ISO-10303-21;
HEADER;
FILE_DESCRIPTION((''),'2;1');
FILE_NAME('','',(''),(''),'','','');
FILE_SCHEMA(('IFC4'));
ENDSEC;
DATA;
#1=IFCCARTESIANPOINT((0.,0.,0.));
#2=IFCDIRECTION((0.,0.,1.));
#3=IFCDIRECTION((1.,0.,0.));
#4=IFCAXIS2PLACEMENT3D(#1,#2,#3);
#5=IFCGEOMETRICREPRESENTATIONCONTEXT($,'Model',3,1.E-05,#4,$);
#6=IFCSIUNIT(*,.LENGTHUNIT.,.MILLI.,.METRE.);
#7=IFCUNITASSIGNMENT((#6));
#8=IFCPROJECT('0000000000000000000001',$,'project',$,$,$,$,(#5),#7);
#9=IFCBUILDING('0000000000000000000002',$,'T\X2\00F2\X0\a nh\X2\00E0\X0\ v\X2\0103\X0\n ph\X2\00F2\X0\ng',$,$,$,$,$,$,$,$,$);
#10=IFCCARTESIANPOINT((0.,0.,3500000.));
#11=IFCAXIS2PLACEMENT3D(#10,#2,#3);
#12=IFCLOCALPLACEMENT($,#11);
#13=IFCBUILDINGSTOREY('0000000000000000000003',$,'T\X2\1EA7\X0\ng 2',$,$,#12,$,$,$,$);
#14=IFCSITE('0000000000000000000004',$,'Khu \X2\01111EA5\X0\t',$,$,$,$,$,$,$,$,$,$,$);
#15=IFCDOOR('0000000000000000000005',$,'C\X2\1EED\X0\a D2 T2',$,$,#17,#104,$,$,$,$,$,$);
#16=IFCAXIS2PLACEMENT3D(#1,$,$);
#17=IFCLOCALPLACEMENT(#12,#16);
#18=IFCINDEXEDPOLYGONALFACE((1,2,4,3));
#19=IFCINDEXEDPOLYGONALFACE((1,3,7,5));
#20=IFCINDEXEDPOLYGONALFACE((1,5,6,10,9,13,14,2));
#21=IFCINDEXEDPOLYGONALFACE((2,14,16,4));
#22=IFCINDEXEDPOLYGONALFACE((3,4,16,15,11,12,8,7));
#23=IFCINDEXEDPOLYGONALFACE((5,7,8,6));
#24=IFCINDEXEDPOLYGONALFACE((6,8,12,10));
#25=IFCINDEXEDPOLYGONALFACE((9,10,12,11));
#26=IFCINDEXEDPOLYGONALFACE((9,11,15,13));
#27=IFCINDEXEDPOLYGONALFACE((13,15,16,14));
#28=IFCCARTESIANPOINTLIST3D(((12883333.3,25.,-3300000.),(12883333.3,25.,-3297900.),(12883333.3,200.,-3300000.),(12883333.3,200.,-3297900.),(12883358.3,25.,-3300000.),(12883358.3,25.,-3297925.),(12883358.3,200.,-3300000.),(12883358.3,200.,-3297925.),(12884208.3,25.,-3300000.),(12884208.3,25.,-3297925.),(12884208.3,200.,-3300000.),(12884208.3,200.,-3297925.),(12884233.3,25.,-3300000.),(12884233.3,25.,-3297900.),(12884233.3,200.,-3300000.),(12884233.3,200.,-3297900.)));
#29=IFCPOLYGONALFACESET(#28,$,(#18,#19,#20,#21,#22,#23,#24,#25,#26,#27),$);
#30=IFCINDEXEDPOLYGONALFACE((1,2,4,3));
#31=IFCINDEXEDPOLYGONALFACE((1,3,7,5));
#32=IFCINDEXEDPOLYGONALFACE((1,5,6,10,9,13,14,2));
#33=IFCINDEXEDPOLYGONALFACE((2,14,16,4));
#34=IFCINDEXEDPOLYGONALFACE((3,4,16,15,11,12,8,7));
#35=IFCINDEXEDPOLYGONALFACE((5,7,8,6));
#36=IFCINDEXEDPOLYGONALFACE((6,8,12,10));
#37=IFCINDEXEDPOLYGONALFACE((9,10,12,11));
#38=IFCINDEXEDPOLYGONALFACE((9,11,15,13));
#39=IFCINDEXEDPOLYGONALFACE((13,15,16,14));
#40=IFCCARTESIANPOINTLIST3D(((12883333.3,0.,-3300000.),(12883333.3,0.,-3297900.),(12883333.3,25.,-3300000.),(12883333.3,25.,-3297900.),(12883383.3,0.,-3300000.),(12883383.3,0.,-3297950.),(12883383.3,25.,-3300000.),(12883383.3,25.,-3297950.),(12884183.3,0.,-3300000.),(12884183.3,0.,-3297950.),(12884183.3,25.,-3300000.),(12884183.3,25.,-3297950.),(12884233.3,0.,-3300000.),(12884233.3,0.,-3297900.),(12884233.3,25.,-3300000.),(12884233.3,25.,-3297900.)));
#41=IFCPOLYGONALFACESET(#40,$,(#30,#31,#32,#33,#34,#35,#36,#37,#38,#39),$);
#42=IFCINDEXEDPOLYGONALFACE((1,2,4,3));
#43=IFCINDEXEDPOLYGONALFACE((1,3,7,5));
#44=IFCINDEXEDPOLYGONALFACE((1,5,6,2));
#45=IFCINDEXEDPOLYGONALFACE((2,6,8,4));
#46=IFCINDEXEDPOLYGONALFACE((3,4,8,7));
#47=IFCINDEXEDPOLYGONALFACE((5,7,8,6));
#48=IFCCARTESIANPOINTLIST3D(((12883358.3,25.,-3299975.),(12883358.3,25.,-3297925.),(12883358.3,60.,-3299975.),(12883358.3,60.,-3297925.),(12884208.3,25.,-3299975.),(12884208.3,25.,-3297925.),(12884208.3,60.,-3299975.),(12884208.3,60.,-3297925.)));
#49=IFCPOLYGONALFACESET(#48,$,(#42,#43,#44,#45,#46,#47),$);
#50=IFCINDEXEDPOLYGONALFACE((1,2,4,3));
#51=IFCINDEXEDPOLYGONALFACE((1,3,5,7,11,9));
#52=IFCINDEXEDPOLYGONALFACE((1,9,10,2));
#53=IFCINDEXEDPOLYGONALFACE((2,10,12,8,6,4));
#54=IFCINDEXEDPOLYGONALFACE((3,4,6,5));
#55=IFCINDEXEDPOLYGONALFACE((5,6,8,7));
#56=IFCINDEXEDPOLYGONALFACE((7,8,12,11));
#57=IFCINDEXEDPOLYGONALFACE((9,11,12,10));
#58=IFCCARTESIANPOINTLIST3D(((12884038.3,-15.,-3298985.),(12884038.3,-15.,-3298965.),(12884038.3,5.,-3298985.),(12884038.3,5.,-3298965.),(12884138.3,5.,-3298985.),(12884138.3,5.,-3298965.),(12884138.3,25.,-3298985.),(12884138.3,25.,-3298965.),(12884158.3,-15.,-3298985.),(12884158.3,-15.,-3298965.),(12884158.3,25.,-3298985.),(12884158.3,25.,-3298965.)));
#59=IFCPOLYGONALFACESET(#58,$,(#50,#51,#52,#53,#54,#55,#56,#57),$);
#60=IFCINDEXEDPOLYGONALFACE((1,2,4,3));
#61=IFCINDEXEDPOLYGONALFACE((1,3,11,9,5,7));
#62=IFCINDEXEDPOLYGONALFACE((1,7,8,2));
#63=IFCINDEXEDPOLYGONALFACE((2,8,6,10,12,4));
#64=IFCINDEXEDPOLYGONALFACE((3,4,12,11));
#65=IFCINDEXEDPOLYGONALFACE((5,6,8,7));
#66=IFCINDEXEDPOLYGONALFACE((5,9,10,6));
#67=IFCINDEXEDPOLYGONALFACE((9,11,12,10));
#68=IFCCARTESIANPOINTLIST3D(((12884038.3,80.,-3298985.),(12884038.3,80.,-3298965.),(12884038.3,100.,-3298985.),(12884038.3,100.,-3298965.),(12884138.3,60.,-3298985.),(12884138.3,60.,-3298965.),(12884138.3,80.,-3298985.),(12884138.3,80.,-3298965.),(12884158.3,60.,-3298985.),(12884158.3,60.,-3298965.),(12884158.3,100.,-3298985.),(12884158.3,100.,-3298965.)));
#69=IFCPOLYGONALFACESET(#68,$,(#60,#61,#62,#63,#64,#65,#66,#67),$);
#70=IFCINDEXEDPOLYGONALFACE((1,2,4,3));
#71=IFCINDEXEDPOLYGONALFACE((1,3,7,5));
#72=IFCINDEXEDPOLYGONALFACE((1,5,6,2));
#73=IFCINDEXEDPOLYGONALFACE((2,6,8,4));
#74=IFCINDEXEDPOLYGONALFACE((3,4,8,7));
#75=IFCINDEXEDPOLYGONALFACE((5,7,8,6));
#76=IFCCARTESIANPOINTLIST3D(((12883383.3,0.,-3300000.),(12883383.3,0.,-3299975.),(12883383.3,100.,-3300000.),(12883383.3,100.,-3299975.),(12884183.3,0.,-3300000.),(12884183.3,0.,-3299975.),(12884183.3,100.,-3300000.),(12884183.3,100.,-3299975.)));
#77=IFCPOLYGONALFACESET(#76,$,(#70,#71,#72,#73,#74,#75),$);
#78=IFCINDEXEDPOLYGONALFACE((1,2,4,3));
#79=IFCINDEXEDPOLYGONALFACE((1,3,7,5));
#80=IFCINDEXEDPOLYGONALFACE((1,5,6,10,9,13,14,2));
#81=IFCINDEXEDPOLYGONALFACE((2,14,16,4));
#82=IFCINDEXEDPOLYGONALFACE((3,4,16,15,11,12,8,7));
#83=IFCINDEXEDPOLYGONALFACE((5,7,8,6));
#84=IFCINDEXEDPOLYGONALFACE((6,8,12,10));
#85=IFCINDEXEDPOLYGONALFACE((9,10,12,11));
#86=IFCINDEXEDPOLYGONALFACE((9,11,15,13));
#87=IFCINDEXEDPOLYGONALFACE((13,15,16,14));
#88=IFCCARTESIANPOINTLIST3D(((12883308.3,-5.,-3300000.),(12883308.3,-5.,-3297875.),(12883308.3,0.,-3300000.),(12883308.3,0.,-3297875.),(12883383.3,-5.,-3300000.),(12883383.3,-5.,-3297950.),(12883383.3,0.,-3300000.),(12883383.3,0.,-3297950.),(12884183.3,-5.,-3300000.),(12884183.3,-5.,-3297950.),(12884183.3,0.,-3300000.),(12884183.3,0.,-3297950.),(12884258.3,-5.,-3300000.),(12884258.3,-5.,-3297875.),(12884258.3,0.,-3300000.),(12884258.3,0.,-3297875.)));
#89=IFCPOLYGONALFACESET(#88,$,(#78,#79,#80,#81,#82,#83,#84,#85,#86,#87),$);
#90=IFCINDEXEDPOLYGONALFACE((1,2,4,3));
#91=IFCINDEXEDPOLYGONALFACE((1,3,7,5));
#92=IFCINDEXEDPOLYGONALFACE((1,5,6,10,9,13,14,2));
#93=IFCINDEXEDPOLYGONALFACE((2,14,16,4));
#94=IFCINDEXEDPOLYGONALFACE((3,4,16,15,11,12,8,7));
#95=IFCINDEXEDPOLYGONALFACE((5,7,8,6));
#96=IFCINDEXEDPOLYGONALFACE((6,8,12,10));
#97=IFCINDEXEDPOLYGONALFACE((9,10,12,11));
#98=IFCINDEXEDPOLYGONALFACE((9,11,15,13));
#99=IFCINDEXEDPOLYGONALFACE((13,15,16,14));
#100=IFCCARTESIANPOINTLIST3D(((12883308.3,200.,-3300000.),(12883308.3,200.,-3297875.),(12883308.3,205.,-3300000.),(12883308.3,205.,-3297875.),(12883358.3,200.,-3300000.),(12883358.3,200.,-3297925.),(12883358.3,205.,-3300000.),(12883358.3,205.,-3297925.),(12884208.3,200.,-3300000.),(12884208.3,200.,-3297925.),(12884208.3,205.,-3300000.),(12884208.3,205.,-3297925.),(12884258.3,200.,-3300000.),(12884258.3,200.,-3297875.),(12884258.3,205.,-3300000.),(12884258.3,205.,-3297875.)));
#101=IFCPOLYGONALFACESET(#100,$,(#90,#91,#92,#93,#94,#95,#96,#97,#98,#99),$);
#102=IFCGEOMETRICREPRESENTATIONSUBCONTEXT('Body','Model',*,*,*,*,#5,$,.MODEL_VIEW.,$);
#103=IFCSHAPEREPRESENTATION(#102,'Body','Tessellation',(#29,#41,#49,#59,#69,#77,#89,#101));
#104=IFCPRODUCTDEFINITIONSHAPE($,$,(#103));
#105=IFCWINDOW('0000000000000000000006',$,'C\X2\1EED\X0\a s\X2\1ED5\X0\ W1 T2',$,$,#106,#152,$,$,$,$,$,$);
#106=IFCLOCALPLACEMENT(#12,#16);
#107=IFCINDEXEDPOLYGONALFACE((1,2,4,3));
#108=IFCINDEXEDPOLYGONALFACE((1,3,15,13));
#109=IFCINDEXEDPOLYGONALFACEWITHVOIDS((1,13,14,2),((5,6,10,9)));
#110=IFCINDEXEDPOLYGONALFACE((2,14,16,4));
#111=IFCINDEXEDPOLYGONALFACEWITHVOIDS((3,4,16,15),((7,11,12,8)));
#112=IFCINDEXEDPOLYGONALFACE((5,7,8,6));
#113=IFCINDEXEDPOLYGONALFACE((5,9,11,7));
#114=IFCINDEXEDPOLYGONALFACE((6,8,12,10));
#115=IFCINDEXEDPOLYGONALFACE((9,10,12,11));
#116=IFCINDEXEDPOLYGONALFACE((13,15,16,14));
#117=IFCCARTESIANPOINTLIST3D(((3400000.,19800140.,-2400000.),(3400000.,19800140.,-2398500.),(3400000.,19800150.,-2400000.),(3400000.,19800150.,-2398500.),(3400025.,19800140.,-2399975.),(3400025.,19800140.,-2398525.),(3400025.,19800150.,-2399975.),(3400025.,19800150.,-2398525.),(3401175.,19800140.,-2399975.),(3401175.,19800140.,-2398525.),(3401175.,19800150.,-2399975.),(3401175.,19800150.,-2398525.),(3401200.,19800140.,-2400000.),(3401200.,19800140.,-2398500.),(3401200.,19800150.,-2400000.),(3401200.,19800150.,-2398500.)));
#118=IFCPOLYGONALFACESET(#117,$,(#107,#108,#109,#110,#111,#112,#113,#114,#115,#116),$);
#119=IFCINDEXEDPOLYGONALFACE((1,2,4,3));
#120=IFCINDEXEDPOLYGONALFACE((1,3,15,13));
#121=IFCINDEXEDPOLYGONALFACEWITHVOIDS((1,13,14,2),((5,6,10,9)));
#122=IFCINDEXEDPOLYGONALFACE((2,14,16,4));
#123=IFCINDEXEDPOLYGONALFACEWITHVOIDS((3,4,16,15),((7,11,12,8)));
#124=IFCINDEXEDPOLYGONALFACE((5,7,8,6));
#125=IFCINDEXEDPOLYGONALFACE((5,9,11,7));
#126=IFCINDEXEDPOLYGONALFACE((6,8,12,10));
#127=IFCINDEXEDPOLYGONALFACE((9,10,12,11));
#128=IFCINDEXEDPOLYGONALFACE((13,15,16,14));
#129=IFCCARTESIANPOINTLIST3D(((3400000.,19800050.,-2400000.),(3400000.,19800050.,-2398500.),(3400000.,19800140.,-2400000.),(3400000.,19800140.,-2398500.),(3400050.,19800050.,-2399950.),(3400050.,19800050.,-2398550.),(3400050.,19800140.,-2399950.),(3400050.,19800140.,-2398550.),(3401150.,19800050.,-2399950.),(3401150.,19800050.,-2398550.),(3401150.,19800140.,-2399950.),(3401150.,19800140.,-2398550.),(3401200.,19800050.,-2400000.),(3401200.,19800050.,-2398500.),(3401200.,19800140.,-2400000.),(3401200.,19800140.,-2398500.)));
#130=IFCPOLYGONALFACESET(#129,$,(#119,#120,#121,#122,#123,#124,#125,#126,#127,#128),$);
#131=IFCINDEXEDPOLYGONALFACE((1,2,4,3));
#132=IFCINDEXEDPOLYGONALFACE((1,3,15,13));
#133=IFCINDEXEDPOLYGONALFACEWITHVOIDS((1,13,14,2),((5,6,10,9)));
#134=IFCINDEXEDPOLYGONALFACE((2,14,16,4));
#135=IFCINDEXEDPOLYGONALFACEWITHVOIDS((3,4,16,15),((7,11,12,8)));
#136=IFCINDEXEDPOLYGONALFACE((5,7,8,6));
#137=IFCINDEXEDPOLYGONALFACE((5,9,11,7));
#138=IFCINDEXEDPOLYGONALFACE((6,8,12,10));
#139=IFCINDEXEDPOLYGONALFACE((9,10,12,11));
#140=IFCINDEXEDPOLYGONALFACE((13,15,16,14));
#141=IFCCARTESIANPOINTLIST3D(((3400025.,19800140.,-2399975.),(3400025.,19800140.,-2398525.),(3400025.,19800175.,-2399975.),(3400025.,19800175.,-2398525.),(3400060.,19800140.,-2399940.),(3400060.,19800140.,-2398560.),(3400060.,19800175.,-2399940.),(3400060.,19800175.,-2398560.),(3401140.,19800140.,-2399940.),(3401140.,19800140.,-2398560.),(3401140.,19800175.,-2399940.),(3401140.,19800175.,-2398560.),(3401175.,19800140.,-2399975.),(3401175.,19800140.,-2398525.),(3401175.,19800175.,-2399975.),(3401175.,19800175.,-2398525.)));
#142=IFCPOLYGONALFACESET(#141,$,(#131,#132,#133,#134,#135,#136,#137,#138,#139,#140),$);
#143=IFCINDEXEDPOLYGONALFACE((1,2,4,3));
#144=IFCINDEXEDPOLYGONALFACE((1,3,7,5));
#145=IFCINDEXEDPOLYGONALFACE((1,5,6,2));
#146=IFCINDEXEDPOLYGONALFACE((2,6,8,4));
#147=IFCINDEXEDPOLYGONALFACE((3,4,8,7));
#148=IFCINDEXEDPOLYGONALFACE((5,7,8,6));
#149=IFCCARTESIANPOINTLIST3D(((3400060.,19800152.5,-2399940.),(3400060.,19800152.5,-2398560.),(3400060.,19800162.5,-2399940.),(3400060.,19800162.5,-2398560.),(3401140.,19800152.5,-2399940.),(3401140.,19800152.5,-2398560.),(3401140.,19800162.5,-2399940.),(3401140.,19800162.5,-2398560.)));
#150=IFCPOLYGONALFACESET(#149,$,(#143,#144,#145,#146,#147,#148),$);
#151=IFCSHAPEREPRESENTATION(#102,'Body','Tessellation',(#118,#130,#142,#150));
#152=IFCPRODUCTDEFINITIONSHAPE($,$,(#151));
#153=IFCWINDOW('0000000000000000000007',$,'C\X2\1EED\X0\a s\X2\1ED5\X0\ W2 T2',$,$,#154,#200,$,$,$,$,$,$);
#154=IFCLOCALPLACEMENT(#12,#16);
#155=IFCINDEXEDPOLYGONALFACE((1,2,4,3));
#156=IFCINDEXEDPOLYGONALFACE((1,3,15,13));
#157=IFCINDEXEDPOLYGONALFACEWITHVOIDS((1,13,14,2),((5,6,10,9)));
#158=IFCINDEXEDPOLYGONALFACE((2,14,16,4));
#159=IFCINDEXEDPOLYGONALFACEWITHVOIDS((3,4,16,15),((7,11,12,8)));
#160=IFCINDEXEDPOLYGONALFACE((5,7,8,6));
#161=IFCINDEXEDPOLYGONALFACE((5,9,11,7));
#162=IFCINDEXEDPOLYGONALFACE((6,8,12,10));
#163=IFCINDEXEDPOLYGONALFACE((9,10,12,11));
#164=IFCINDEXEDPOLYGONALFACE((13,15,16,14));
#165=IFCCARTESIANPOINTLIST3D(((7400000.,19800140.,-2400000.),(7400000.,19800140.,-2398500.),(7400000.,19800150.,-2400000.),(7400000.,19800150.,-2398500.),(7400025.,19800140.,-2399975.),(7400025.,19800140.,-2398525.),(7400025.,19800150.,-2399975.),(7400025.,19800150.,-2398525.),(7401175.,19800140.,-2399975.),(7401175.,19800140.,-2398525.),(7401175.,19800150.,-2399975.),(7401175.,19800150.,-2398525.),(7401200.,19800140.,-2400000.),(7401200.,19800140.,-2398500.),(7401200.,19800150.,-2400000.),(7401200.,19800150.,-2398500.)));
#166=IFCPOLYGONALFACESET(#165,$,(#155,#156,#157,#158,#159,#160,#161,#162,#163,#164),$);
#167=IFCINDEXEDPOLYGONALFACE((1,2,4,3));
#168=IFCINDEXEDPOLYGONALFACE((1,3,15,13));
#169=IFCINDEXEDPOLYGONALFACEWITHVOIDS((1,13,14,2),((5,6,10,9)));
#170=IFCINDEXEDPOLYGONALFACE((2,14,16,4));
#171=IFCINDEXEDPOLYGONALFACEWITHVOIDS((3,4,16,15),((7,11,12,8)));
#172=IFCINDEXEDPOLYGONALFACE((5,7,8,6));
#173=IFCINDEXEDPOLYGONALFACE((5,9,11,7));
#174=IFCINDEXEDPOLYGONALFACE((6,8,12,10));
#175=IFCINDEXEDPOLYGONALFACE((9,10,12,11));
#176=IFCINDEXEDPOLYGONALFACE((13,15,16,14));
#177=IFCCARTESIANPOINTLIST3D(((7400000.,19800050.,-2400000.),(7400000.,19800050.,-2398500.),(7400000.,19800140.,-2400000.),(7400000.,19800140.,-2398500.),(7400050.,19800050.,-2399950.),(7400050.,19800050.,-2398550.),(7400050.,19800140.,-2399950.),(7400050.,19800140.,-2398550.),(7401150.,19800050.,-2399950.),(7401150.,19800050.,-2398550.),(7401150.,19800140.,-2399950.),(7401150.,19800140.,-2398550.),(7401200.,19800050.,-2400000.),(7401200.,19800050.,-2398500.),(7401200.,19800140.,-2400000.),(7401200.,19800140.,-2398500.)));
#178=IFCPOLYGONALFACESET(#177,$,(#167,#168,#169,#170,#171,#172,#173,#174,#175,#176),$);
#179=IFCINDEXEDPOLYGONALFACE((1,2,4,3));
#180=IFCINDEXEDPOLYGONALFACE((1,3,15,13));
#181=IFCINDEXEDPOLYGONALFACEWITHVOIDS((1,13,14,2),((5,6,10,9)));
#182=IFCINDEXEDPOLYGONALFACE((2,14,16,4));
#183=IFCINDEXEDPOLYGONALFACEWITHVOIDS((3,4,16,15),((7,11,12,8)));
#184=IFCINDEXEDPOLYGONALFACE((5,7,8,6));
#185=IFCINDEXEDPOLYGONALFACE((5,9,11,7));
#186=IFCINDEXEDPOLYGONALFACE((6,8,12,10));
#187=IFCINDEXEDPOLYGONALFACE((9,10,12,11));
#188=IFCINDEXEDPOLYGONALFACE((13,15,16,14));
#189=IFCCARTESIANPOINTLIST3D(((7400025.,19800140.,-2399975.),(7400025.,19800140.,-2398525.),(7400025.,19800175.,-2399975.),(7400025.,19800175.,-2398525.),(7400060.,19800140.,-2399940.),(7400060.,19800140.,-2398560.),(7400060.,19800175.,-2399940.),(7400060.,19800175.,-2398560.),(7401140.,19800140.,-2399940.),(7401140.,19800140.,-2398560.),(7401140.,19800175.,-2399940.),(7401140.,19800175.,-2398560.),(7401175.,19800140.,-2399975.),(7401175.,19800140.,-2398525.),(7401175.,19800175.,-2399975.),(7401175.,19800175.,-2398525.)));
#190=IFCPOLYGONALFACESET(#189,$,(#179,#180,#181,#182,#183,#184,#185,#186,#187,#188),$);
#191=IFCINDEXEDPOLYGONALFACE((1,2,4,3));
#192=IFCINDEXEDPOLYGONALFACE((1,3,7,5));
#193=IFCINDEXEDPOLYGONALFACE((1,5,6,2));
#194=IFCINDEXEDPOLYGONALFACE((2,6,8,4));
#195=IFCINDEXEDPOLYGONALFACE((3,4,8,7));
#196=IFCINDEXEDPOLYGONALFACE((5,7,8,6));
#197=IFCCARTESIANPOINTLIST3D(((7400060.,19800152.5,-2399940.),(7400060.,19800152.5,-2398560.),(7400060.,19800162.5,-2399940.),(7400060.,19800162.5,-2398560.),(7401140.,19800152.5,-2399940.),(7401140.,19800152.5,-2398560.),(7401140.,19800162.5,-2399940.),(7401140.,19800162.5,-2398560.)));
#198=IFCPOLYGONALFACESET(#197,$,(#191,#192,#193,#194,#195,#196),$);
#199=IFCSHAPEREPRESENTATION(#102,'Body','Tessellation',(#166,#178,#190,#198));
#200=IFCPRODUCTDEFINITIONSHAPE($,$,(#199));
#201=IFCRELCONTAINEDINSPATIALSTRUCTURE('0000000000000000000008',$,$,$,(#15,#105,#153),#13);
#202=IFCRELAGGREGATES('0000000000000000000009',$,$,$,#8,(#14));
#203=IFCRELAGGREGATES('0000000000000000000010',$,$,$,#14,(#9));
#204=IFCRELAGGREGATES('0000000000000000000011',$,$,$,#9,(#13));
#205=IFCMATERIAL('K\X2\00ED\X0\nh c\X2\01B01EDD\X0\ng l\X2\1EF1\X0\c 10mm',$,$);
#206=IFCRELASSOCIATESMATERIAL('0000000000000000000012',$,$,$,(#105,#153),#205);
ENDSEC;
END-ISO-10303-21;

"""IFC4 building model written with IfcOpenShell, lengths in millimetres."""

from ifc_helpers import new_model, si_unit, frame, origin_with_axes, place, context, subcontext, project, spatial, line, indexed_curve, outline, extrude, material, element, save


model = new_model("IFC4")

# Units and contexts
model_context = context("Model", 3, precision=1e-05, world=origin_with_axes())
body_context = subcontext(model_context, "Body", "Model", "MODEL_VIEW")
ifc_project = project(units=[si_unit("LENGTHUNIT", "METRE", prefix="MILLI")], contexts=[model_context])

# Site, building, storey
site = spatial("IfcSite", under=ifc_project, Name="Khu đất")
building = spatial("IfcBuilding", under=site, Name="Tòa nhà văn phòng")
storey_placement = place(None, frame((0.0, 0.0, 3500000.0), z_axis=(0.0, 0.0, 1.0), x_axis=(1.0, 0.0, 0.0)))
storey = spatial("IfcBuildingStorey", under=building, at=storey_placement, Name="Tầng 2")

# Door
door_1_placement = place(storey_placement, frame((12883333.3, 0.0, -3300000.0), z_axis=(0.0, 0.0, 1.0), x_axis=(1.0, 0.0, 0.0)))
element("IfcDoor", 1, at=door_1_placement, inside=storey, Name="Cửa D2 T2", context=body_context, shape_type="SolidModel", body=[
    extrude(outline(indexed_curve([(0.0, 0.0), (0.0, 2100.0), (900.0, 2100.0), (900.0, 0.0), (875.0, 0.0), (875.0, 2075.0), (25.0, 2075.0), (25.0, 0.0)], segments=[line(1, 2, 3, 4, 5, 6, 7, 8, 1)])), frame((0.0, 25.0, 0.0), z_axis=(0.0, -1.0, 0.0), x_axis=(1.0, 0.0, 0.0)), (0.0, 0.0, -1.0), 175.0),
    extrude(outline(indexed_curve([(0.0, 0.0), (0.0, 2100.0), (900.0, 2100.0), (900.0, 0.0), (850.0, 0.0), (850.0, 2050.0), (50.0, 2050.0), (50.0, 0.0)], segments=[line(1, 2, 3, 4, 5, 6, 7, 8, 1)])), frame((0.0, 0.0, 0.0), z_axis=(0.0, -1.0, 0.0), x_axis=(1.0, 0.0, 0.0)), (0.0, 0.0, -1.0), 25.0),
    extrude(outline(indexed_curve([(0.0, 0.0), (850.0, 0.0), (850.0, 35.0), (0.0, 35.0)], segments=[line(1, 2, 3, 4, 1)])), frame((25.0, 25.0, 25.0), z_axis=(0.0, 0.0, 1.0), x_axis=(1.0, 0.0, 0.0)), (0.0, 0.0, 1.0), 2050.0),
    extrude(outline(indexed_curve([(0.0, 0.0), (0.0, -40.0), (-120.0, -40.0), (-120.0, -20.0), (-20.0, -20.0), (-20.0, 0.0)], segments=[line(1, 2, 3, 4, 5, 6, 1)])), frame((825.0, 25.0, 1015.0), z_axis=(0.0, 0.0, 1.0), x_axis=(1.0, 0.0, 0.0)), (0.0, 0.0, 1.0), 20.0),
    extrude(outline(indexed_curve([(0.0, 0.0), (0.0, 40.0), (-120.0, 40.0), (-120.0, 20.0), (-20.0, 20.0), (-20.0, 0.0)], segments=[line(1, 2, 3, 4, 5, 6, 1)])), frame((825.0, 60.0, 1015.0), z_axis=(0.0, 0.0, 1.0), x_axis=(1.0, 0.0, 0.0)), (0.0, 0.0, 1.0), 20.0),
    extrude(outline(indexed_curve([(0.0, 0.0), (800.0, 0.0), (800.0, 100.0), (0.0, 100.0)], segments=[line(1, 2, 3, 4, 1)])), frame((50.0, 0.0, 0.0), z_axis=(0.0, 0.0, 1.0), x_axis=(1.0, 0.0, 0.0)), (0.0, 0.0, 1.0), 25.0),
    extrude(outline(indexed_curve([(0.0, 0.0), (0.0, 2125.0), (950.0, 2125.0), (950.0, 0.0), (875.0, 0.0), (875.0, 2050.0), (75.0, 2050.0), (75.0, 0.0)], segments=[line(1, 2, 3, 4, 5, 6, 7, 8, 1)])), frame((-25.0, -5.0, 0.0), z_axis=(0.0, -1.0, 0.0), x_axis=(1.0, 0.0, 0.0)), (0.0, 0.0, -1.0), 5.0),
    extrude(outline(indexed_curve([(0.0, 0.0), (0.0, 2125.0), (950.0, 2125.0), (950.0, 0.0), (900.0, 0.0), (900.0, 2075.0), (50.0, 2075.0), (50.0, 0.0)], segments=[line(1, 2, 3, 4, 5, 6, 7, 8, 1)])), frame((-25.0, 200.0, 0.0), z_axis=(0.0, -1.0, 0.0), x_axis=(1.0, 0.0, 0.0)), (0.0, 0.0, -1.0), 5.0),
])

# Windows
ifc_material_1 = material(Name="Kính cường lực 10mm")
for number, where, z_axis, x_axis, name in (
    (2, (3400000.0, 19800000.0, -2400000.0), (0.0, 0.0, 1.0), (1.0, 0.0, 0.0), "Cửa sổ W1 T2"),
    (3, (7400000.0, 19800000.0, -2400000.0), (0.0, 0.0, 1.0), (1.0, 0.0, 0.0), "Cửa sổ W2 T2"),
):
    element("IfcWindow", number, at=place(storey_placement, frame(where, z_axis=z_axis, x_axis=x_axis)), inside=storey, material=ifc_material_1, Name=name, context=body_context, shape_type="SolidModel", body=[
        extrude(outline(indexed_curve([(0.0, 0.0), (1200.0, 0.0), (1200.0, 1500.0), (0.0, 1500.0)], segments=[line(1, 2, 3, 4, 1)]), holes=[indexed_curve([(25.0, 25.0), (1175.0, 25.0), (1175.0, 1475.0), (25.0, 1475.0)], segments=[line(1, 2, 3, 4, 1)])]), frame((0.0, 140.0, 0.0), z_axis=(0.0, -1.0, 0.0), x_axis=(1.0, 0.0, 0.0)), (0.0, 0.0, -1.0), 10.0),
        extrude(outline(indexed_curve([(0.0, 0.0), (1200.0, 0.0), (1200.0, 1500.0), (0.0, 1500.0)], segments=[line(1, 2, 3, 4, 1)]), holes=[indexed_curve([(50.0, 50.0), (1150.0, 50.0), (1150.0, 1450.0), (50.0, 1450.0)], segments=[line(1, 2, 3, 4, 1)])]), frame((0.0, 50.0, 0.0), z_axis=(0.0, -1.0, 0.0), x_axis=(1.0, 0.0, 0.0)), (0.0, 0.0, -1.0), 90.0),
        extrude(outline(indexed_curve([(0.0, 0.0), (1150.0, 0.0), (1150.0, 1450.0), (0.0, 1450.0)], segments=[line(1, 2, 3, 4, 1)]), holes=[indexed_curve([(35.0, 35.0), (1115.0, 35.0), (1115.0, 1415.0), (35.0, 1415.0)], segments=[line(1, 2, 3, 4, 1)])]), frame((25.0, 140.0, 25.0), z_axis=(0.0, -1.0, 0.0), x_axis=(1.0, 0.0, 0.0)), (0.0, 0.0, -1.0), 35.0),
        extrude(outline(indexed_curve([(35.0, 35.0), (1115.0, 35.0), (1115.0, 1415.0), (35.0, 1415.0)], segments=[line(1, 2, 3, 4, 1)])), frame((25.0, 152.5, 25.0), z_axis=(0.0, -1.0, 0.0), x_axis=(1.0, 0.0, 0.0)), (0.0, 0.0, -1.0), 10.0),
    ])

save(model, "model.ifc")
